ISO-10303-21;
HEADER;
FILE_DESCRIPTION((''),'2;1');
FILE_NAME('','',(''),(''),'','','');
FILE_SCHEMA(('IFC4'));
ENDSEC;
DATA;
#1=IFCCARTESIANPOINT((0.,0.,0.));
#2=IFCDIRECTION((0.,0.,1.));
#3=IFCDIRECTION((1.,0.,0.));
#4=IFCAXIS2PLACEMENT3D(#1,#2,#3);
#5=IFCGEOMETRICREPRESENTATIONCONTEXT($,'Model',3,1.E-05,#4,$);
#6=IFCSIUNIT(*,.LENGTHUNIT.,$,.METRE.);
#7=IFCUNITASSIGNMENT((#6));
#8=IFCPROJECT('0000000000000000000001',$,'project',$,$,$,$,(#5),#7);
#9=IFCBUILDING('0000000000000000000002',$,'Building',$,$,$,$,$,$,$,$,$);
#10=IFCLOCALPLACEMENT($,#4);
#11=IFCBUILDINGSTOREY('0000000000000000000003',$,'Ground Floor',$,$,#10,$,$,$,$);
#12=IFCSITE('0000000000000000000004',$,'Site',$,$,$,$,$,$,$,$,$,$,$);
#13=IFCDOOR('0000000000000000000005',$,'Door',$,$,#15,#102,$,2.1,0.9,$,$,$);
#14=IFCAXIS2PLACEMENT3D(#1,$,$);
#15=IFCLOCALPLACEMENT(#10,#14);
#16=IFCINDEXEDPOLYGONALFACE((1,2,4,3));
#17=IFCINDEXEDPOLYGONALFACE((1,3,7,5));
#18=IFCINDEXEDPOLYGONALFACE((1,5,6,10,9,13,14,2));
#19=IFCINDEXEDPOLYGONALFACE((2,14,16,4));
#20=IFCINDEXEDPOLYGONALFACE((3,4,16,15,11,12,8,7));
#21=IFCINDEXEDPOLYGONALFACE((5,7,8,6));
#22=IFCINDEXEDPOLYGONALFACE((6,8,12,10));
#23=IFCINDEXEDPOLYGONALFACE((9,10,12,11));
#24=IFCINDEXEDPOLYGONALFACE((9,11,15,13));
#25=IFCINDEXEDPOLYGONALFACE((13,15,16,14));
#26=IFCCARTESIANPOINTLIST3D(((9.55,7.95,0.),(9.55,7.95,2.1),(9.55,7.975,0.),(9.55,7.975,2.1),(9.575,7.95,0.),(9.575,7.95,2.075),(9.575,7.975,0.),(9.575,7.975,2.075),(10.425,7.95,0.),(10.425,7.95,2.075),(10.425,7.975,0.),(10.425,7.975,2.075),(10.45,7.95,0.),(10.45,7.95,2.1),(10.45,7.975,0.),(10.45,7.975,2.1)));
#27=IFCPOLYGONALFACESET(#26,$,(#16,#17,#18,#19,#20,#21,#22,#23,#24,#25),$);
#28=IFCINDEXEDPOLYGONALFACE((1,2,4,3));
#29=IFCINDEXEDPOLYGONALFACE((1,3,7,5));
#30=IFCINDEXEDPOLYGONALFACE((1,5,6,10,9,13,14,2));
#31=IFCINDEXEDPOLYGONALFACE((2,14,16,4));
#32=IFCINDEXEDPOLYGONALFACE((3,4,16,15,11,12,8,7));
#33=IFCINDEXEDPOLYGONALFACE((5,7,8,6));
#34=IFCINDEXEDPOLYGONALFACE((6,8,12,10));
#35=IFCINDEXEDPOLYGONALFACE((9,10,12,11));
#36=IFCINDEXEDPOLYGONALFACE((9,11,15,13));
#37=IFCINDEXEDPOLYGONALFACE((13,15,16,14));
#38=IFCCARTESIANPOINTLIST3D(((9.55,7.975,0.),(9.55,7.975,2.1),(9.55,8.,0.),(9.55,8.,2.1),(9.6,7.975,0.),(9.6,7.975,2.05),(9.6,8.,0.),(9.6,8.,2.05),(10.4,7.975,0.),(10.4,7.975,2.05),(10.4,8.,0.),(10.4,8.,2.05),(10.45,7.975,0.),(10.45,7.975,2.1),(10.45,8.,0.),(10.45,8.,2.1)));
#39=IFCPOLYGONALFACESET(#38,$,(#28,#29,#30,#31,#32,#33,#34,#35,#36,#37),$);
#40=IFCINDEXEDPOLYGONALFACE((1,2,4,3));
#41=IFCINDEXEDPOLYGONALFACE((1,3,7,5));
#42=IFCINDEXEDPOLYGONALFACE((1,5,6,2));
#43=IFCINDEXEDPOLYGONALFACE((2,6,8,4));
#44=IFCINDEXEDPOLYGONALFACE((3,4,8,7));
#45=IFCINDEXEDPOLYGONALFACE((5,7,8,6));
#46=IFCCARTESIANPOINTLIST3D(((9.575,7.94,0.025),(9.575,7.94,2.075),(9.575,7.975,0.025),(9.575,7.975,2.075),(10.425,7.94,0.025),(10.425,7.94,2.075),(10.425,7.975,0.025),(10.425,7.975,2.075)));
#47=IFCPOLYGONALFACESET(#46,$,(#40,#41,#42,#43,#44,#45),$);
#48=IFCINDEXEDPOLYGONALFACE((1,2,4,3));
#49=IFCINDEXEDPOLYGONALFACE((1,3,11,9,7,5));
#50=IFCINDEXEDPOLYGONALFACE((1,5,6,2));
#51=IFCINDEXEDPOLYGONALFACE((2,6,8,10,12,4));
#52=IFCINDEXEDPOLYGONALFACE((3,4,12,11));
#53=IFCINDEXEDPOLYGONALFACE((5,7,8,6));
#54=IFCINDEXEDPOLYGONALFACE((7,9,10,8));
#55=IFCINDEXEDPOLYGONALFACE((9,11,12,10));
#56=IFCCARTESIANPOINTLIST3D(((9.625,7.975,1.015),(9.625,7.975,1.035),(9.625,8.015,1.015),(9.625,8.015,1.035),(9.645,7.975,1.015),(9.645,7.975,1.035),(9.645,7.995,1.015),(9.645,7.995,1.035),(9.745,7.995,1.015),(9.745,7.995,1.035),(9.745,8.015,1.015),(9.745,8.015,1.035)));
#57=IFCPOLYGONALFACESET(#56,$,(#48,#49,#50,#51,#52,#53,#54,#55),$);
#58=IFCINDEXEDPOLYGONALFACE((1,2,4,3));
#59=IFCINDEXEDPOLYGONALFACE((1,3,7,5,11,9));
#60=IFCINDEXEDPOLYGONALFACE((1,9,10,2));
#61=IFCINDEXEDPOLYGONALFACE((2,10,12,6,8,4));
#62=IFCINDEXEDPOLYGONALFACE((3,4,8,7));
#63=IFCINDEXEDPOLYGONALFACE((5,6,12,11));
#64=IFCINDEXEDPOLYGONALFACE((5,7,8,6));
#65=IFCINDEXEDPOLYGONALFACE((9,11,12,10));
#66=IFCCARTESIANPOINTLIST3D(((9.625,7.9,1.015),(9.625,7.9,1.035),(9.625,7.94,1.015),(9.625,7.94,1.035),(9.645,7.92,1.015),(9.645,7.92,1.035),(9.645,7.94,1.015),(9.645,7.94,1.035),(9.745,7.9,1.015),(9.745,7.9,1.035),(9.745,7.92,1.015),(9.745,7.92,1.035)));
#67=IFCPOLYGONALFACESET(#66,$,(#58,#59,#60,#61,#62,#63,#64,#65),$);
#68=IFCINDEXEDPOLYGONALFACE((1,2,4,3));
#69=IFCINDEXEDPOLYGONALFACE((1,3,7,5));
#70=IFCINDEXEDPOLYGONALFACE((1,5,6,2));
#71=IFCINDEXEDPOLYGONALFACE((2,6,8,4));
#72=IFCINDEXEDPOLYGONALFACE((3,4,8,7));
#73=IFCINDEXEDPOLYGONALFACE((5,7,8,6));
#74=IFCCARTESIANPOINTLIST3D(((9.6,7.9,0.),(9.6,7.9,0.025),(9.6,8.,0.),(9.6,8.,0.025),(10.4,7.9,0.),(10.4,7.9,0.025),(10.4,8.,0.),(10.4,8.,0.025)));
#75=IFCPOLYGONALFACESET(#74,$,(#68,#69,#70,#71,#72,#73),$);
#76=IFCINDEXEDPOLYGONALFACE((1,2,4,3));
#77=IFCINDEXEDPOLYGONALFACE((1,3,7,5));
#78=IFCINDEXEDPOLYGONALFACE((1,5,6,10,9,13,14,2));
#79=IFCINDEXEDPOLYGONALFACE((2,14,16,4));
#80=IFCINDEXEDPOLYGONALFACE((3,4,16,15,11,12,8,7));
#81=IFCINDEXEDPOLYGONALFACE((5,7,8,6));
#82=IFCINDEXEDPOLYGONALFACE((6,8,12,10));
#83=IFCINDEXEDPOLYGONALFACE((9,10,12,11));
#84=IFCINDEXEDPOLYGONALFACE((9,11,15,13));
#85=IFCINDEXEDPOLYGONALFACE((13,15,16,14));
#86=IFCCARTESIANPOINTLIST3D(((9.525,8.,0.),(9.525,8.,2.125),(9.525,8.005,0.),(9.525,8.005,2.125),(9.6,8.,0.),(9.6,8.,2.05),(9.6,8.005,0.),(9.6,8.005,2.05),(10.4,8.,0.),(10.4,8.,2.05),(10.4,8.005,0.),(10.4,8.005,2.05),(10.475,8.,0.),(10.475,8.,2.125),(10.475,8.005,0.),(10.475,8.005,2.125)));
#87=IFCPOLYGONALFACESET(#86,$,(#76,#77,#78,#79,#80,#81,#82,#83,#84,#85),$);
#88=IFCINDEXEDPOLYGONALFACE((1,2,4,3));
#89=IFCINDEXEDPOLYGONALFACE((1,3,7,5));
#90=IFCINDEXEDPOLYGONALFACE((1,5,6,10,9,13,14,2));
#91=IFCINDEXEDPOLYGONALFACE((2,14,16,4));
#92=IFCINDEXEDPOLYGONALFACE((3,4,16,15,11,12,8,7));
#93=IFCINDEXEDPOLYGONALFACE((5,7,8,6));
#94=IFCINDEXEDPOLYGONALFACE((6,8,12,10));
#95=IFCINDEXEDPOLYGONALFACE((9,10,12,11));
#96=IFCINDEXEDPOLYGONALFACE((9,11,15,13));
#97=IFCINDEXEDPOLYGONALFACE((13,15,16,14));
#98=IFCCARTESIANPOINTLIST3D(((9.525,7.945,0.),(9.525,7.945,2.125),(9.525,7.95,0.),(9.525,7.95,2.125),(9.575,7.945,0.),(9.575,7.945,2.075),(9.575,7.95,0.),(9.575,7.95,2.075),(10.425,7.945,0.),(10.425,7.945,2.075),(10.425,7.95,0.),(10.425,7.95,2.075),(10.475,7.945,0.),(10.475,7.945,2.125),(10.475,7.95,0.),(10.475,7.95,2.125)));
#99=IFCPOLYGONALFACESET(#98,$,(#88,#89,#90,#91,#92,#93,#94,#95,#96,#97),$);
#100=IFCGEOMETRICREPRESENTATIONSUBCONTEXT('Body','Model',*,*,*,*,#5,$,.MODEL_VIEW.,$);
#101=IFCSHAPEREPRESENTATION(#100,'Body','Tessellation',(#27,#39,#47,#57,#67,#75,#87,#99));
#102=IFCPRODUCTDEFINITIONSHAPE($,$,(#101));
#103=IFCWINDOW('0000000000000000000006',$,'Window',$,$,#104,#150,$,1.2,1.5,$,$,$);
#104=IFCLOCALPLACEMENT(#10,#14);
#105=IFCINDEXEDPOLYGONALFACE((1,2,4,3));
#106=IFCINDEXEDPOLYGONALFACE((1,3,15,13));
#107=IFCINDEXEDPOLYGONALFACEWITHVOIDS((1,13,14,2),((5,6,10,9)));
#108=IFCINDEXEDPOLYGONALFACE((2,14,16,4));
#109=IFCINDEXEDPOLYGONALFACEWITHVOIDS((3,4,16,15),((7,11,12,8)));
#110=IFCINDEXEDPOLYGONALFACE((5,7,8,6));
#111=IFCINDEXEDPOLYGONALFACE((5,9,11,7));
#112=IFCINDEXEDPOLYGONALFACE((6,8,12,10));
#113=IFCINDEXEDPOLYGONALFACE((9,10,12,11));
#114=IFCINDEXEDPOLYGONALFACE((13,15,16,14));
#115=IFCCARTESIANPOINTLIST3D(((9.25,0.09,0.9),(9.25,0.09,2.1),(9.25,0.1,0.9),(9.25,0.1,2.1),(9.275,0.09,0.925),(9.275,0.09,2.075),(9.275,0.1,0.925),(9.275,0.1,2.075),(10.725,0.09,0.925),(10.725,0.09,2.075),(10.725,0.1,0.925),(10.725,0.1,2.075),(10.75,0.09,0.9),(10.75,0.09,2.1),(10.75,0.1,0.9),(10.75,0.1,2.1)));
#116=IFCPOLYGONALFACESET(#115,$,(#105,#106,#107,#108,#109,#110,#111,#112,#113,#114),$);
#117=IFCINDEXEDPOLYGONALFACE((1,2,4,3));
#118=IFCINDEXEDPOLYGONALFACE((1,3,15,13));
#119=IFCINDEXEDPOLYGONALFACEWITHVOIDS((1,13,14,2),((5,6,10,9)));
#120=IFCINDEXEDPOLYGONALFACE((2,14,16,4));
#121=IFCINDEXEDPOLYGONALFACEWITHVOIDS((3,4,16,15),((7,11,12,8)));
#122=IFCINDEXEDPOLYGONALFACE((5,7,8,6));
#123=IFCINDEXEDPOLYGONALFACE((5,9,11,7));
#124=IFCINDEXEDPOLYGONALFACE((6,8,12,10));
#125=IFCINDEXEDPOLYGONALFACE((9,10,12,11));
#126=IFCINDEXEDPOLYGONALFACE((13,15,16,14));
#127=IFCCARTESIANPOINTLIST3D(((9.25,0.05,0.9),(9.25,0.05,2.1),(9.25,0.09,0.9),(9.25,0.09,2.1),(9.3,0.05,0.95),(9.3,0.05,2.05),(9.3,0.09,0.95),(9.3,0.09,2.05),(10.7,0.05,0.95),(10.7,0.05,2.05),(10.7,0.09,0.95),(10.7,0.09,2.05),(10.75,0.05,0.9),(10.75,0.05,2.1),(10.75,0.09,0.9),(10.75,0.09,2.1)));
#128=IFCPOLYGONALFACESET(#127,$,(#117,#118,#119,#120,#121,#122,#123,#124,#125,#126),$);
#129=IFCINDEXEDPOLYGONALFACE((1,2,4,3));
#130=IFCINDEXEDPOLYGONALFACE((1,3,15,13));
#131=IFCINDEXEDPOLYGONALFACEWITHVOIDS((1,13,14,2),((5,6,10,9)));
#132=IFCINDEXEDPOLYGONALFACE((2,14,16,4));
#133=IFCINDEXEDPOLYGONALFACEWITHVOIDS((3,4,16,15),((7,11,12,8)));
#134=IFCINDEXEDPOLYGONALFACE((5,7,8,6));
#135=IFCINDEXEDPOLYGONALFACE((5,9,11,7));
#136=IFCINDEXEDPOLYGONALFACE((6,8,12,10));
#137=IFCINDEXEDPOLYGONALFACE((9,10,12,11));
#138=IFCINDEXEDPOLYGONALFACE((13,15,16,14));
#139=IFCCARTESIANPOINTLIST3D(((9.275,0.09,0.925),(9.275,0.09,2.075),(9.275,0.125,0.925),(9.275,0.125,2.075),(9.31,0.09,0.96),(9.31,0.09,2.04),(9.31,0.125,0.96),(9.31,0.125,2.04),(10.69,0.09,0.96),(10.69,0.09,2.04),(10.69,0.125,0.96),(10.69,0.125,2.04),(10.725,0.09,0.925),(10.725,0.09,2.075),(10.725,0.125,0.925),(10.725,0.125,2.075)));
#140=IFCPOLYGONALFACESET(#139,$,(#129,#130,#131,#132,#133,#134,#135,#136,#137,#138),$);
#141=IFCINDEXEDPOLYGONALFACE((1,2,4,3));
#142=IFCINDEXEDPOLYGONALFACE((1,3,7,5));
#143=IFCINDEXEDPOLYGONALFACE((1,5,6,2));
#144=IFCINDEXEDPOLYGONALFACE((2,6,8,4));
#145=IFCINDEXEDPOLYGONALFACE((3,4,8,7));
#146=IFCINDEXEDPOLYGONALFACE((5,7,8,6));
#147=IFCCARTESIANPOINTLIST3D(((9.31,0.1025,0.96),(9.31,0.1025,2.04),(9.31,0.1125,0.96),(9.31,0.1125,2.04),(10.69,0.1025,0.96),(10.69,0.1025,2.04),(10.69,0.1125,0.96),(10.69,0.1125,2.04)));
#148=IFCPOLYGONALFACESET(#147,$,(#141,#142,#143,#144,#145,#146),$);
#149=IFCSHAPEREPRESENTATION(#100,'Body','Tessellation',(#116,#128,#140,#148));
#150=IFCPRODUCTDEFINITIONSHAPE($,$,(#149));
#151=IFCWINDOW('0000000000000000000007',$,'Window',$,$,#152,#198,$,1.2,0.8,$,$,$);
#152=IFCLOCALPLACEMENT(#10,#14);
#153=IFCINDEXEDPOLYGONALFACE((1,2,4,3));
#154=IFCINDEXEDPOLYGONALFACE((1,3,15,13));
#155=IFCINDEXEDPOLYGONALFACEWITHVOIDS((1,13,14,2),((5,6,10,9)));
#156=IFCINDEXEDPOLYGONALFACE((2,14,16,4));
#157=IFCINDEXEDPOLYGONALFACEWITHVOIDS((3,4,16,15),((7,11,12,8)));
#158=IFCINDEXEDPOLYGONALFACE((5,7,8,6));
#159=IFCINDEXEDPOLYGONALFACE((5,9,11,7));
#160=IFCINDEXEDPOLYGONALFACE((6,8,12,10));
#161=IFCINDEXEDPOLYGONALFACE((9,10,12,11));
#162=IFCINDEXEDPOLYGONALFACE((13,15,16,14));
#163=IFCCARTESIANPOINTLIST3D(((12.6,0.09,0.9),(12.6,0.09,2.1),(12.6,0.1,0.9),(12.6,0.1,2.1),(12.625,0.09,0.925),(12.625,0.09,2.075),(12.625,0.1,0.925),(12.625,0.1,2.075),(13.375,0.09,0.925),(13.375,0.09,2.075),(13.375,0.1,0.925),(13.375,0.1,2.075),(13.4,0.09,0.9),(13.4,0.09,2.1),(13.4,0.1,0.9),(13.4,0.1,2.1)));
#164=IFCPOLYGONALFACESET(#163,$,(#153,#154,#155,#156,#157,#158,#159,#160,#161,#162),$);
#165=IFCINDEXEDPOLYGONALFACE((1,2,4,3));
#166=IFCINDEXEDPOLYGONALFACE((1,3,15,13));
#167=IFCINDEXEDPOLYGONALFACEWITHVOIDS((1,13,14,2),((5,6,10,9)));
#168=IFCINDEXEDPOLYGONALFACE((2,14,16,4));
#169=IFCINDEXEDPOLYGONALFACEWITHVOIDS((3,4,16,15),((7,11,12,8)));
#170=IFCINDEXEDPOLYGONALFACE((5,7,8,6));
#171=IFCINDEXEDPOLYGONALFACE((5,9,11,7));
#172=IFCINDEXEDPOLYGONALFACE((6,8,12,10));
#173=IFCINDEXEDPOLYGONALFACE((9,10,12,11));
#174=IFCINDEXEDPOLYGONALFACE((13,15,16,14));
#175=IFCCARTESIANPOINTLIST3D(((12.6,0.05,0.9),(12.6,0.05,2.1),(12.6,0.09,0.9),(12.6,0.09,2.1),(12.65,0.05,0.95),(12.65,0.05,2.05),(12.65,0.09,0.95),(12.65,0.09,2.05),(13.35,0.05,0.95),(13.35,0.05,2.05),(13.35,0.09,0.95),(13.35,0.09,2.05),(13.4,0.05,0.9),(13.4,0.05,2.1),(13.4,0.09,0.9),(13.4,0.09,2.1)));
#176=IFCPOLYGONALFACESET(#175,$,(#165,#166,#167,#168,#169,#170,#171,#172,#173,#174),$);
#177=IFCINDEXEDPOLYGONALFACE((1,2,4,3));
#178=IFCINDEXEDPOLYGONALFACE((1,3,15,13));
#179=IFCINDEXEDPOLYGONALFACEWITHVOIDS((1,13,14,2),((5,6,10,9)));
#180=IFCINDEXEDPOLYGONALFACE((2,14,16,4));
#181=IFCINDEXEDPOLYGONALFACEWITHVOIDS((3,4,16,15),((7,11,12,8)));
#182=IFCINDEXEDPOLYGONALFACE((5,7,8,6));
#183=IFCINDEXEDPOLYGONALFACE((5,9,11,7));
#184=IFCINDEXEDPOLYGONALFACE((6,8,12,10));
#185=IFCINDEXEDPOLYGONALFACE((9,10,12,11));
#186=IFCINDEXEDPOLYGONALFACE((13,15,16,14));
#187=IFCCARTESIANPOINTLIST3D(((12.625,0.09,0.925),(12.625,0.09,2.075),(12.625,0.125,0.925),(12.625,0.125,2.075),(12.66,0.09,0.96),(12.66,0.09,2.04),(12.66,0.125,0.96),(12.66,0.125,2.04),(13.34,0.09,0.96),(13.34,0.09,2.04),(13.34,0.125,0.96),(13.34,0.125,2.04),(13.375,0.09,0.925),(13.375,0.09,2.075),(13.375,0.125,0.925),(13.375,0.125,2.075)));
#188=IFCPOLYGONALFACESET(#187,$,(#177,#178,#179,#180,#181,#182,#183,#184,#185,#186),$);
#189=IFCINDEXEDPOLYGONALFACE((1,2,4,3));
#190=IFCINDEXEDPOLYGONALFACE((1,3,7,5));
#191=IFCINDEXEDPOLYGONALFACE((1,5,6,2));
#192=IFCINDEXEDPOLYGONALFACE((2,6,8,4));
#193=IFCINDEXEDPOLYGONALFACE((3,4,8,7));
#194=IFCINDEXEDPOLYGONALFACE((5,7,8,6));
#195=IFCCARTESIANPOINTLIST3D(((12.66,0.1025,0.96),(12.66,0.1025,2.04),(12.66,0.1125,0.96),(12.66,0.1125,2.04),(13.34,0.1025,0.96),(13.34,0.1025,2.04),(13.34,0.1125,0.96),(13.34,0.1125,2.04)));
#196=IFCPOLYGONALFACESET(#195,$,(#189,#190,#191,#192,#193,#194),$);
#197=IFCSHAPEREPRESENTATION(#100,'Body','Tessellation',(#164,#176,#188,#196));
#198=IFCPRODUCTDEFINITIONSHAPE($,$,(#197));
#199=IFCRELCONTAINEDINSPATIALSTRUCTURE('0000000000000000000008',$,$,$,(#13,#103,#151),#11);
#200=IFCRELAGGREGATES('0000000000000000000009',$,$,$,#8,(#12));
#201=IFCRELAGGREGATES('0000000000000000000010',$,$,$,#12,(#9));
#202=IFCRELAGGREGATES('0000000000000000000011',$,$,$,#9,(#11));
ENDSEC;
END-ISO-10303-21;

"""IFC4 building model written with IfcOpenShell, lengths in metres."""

from ifc_helpers import new_model, si_unit, frame, origin_with_axes, place, context, subcontext, project, spatial, line, indexed_curve, outline, extrude, element, save


model = new_model("IFC4")

# Units and contexts
model_context = context("Model", 3, precision=1e-05, world=origin_with_axes())
body_context = subcontext(model_context, "Body", "Model", "MODEL_VIEW")
ifc_project = project(units=[si_unit("LENGTHUNIT", "METRE")], contexts=[model_context])

# Site, building, storey
site = spatial("IfcSite", under=ifc_project, Name="Site")
building = spatial("IfcBuilding", under=site, Name="Building")
storey_placement = place(None, origin_with_axes())
storey = spatial("IfcBuildingStorey", under=building, at=storey_placement, Name="Ground Floor")

# Door
door_1_placement = place(storey_placement, frame((10.45, 8.0, 0.0), z_axis=(0.0, 0.0, 1.0), x_axis=(-1.0, 0.0, 0.0)))
element("IfcDoor", 1, at=door_1_placement, inside=storey, Name="Door", OverallHeight=2.1, OverallWidth=0.9, context=body_context, shape_type="SweptSolid", body=[
    extrude(outline(indexed_curve([(0.0, 0.0), (0.0, 2.1), (0.9, 2.1), (0.9, 0.0), (0.875, 0.0), (0.875, 2.075), (0.025, 2.075), (0.025, 0.0)], segments=[line(1, 2, 3, 4, 5, 6, 7, 8, 1)])), frame((0.0, 0.025, 0.0), z_axis=(0.0, -1.0, 0.0), x_axis=(1.0, 0.0, 0.0)), (0.0, 0.0, -1.0), 0.025),
    extrude(outline(indexed_curve([(0.0, 0.0), (0.0, 2.1), (0.9, 2.1), (0.9, 0.0), (0.85, 0.0), (0.85, 2.05), (0.05, 2.05), (0.05, 0.0)], segments=[line(1, 2, 3, 4, 5, 6, 7, 8, 1)])), frame((0.0, 0.0, 0.0), z_axis=(0.0, -1.0, 0.0), x_axis=(1.0, 0.0, 0.0)), (0.0, 0.0, -1.0), 0.025),
    extrude(outline(indexed_curve([(0.0, 0.0), (0.85, 0.0), (0.85, 0.035), (0.0, 0.035)], segments=[line(1, 2, 3, 4, 1)])), frame((0.025, 0.025, 0.025), z_axis=(0.0, 0.0, 1.0), x_axis=(1.0, 0.0, 0.0)), (0.0, 0.0, 1.0), 2.05),
    extrude(outline(indexed_curve([(0.0, 0.0), (0.0, -0.04), (-0.12, -0.04), (-0.12, -0.02), (-0.02, -0.02), (-0.02, 0.0)], segments=[line(1, 2, 3, 4, 5, 6, 1)])), frame((0.825, 0.025, 1.015), z_axis=(0.0, 0.0, 1.0), x_axis=(1.0, 0.0, 0.0)), (0.0, 0.0, 1.0), 0.02),
    extrude(outline(indexed_curve([(0.0, 0.0), (0.0, 0.04), (-0.12, 0.04), (-0.12, 0.02), (-0.02, 0.02), (-0.02, 0.0)], segments=[line(1, 2, 3, 4, 5, 6, 1)])), frame((0.825, 0.06, 1.015), z_axis=(0.0, 0.0, 1.0), x_axis=(1.0, 0.0, 0.0)), (0.0, 0.0, 1.0), 0.02),
    extrude(outline(indexed_curve([(0.0, 0.0), (0.8, 0.0), (0.8, 0.1), (0.0, 0.1)], segments=[line(1, 2, 3, 4, 1)])), frame((0.05, 0.0, 0.0), z_axis=(0.0, 0.0, 1.0), x_axis=(1.0, 0.0, 0.0)), (0.0, 0.0, 1.0), 0.025),
    extrude(outline(indexed_curve([(0.0, 0.0), (0.0, 2.125), (0.95, 2.125), (0.95, 0.0), (0.875, 0.0), (0.875, 2.05), (0.075, 2.05), (0.075, 0.0)], segments=[line(1, 2, 3, 4, 5, 6, 7, 8, 1)])), frame((-0.025, -0.005, 0.0), z_axis=(0.0, -1.0, 0.0), x_axis=(1.0, 0.0, 0.0)), (0.0, 0.0, -1.0), 0.005),
    extrude(outline(indexed_curve([(0.0, 0.0), (0.0, 2.125), (0.95, 2.125), (0.95, 0.0), (0.9, 0.0), (0.9, 2.075), (0.05, 2.075), (0.05, 0.0)], segments=[line(1, 2, 3, 4, 5, 6, 7, 8, 1)])), frame((-0.025, 0.05, 0.0), z_axis=(0.0, -1.0, 0.0), x_axis=(1.0, 0.0, 0.0)), (0.0, 0.0, -1.0), 0.005),
])

# Windows
window_1_placement = place(storey_placement, frame((9.25, 0.0, 0.9), z_axis=(0.0, 0.0, 1.0), x_axis=(1.0, 0.0, 0.0)))
element("IfcWindow", 2, at=window_1_placement, inside=storey, Name="Window", OverallHeight=1.2, OverallWidth=1.5, context=body_context, shape_type="SweptSolid", body=[
    extrude(outline(indexed_curve([(0.0, 0.0), (1.5, 0.0), (1.5, 1.2), (0.0, 1.2)], segments=[line(1, 2, 3, 4, 1)]), holes=[indexed_curve([(0.025, 0.025), (1.475, 0.025), (1.475, 1.175), (0.025, 1.175)], segments=[line(1, 2, 3, 4, 1)])]), frame((0.0, 0.09, 0.0), z_axis=(0.0, -1.0, 0.0), x_axis=(1.0, 0.0, 0.0)), (0.0, 0.0, -1.0), 0.01),
    extrude(outline(indexed_curve([(0.0, 0.0), (1.5, 0.0), (1.5, 1.2), (0.0, 1.2)], segments=[line(1, 2, 3, 4, 1)]), holes=[indexed_curve([(0.05, 0.05), (1.45, 0.05), (1.45, 1.15), (0.05, 1.15)], segments=[line(1, 2, 3, 4, 1)])]), frame((0.0, 0.05, 0.0), z_axis=(0.0, -1.0, 0.0), x_axis=(1.0, 0.0, 0.0)), (0.0, 0.0, -1.0), 0.04),
    extrude(outline(indexed_curve([(0.0, 0.0), (1.45, 0.0), (1.45, 1.15), (0.0, 1.15)], segments=[line(1, 2, 3, 4, 1)]), holes=[indexed_curve([(0.035, 0.035), (1.415, 0.035), (1.415, 1.115), (0.035, 1.115)], segments=[line(1, 2, 3, 4, 1)])]), frame((0.025, 0.09, 0.025), z_axis=(0.0, -1.0, 0.0), x_axis=(1.0, 0.0, 0.0)), (0.0, 0.0, -1.0), 0.035),
    extrude(outline(indexed_curve([(0.035, 0.035), (1.415, 0.035), (1.415, 1.115), (0.035, 1.115)], segments=[line(1, 2, 3, 4, 1)])), frame((0.025, 0.1025, 0.025), z_axis=(0.0, -1.0, 0.0), x_axis=(1.0, 0.0, 0.0)), (0.0, 0.0, -1.0), 0.01),
])
window_2_placement = place(storey_placement, frame((12.6, 0.0, 0.9), z_axis=(0.0, 0.0, 1.0), x_axis=(1.0, 0.0, 0.0)))
element("IfcWindow", 3, at=window_2_placement, inside=storey, Name="Window", OverallHeight=1.2, OverallWidth=0.8, context=body_context, shape_type="SweptSolid", body=[
    extrude(outline(indexed_curve([(0.0, 0.0), (0.8, 0.0), (0.8, 1.2), (0.0, 1.2)], segments=[line(1, 2, 3, 4, 1)]), holes=[indexed_curve([(0.025, 0.025), (0.775, 0.025), (0.775, 1.175), (0.025, 1.175)], segments=[line(1, 2, 3, 4, 1)])]), frame((0.0, 0.09, 0.0), z_axis=(0.0, -1.0, 0.0), x_axis=(1.0, 0.0, 0.0)), (0.0, 0.0, -1.0), 0.01),
    extrude(outline(indexed_curve([(0.0, 0.0), (0.8, 0.0), (0.8, 1.2), (0.0, 1.2)], segments=[line(1, 2, 3, 4, 1)]), holes=[indexed_curve([(0.05, 0.05), (0.75, 0.05), (0.75, 1.15), (0.05, 1.15)], segments=[line(1, 2, 3, 4, 1)])]), frame((0.0, 0.05, 0.0), z_axis=(0.0, -1.0, 0.0), x_axis=(1.0, 0.0, 0.0)), (0.0, 0.0, -1.0), 0.04),
    extrude(outline(indexed_curve([(0.0, 0.0), (0.75, 0.0), (0.75, 1.15), (0.0, 1.15)], segments=[line(1, 2, 3, 4, 1)]), holes=[indexed_curve([(0.035, 0.035), (0.715, 0.035), (0.715, 1.115), (0.035, 1.115)], segments=[line(1, 2, 3, 4, 1)])]), frame((0.025, 0.09, 0.025), z_axis=(0.0, -1.0, 0.0), x_axis=(1.0, 0.0, 0.0)), (0.0, 0.0, -1.0), 0.035),
    extrude(outline(indexed_curve([(0.035, 0.035), (0.715, 0.035), (0.715, 1.115), (0.035, 1.115)], segments=[line(1, 2, 3, 4, 1)])), frame((0.025, 0.1025, 0.025), z_axis=(0.0, -1.0, 0.0), x_axis=(1.0, 0.0, 0.0)), (0.0, 0.0, -1.0), 0.01),
])

save(model, "model.ifc")
